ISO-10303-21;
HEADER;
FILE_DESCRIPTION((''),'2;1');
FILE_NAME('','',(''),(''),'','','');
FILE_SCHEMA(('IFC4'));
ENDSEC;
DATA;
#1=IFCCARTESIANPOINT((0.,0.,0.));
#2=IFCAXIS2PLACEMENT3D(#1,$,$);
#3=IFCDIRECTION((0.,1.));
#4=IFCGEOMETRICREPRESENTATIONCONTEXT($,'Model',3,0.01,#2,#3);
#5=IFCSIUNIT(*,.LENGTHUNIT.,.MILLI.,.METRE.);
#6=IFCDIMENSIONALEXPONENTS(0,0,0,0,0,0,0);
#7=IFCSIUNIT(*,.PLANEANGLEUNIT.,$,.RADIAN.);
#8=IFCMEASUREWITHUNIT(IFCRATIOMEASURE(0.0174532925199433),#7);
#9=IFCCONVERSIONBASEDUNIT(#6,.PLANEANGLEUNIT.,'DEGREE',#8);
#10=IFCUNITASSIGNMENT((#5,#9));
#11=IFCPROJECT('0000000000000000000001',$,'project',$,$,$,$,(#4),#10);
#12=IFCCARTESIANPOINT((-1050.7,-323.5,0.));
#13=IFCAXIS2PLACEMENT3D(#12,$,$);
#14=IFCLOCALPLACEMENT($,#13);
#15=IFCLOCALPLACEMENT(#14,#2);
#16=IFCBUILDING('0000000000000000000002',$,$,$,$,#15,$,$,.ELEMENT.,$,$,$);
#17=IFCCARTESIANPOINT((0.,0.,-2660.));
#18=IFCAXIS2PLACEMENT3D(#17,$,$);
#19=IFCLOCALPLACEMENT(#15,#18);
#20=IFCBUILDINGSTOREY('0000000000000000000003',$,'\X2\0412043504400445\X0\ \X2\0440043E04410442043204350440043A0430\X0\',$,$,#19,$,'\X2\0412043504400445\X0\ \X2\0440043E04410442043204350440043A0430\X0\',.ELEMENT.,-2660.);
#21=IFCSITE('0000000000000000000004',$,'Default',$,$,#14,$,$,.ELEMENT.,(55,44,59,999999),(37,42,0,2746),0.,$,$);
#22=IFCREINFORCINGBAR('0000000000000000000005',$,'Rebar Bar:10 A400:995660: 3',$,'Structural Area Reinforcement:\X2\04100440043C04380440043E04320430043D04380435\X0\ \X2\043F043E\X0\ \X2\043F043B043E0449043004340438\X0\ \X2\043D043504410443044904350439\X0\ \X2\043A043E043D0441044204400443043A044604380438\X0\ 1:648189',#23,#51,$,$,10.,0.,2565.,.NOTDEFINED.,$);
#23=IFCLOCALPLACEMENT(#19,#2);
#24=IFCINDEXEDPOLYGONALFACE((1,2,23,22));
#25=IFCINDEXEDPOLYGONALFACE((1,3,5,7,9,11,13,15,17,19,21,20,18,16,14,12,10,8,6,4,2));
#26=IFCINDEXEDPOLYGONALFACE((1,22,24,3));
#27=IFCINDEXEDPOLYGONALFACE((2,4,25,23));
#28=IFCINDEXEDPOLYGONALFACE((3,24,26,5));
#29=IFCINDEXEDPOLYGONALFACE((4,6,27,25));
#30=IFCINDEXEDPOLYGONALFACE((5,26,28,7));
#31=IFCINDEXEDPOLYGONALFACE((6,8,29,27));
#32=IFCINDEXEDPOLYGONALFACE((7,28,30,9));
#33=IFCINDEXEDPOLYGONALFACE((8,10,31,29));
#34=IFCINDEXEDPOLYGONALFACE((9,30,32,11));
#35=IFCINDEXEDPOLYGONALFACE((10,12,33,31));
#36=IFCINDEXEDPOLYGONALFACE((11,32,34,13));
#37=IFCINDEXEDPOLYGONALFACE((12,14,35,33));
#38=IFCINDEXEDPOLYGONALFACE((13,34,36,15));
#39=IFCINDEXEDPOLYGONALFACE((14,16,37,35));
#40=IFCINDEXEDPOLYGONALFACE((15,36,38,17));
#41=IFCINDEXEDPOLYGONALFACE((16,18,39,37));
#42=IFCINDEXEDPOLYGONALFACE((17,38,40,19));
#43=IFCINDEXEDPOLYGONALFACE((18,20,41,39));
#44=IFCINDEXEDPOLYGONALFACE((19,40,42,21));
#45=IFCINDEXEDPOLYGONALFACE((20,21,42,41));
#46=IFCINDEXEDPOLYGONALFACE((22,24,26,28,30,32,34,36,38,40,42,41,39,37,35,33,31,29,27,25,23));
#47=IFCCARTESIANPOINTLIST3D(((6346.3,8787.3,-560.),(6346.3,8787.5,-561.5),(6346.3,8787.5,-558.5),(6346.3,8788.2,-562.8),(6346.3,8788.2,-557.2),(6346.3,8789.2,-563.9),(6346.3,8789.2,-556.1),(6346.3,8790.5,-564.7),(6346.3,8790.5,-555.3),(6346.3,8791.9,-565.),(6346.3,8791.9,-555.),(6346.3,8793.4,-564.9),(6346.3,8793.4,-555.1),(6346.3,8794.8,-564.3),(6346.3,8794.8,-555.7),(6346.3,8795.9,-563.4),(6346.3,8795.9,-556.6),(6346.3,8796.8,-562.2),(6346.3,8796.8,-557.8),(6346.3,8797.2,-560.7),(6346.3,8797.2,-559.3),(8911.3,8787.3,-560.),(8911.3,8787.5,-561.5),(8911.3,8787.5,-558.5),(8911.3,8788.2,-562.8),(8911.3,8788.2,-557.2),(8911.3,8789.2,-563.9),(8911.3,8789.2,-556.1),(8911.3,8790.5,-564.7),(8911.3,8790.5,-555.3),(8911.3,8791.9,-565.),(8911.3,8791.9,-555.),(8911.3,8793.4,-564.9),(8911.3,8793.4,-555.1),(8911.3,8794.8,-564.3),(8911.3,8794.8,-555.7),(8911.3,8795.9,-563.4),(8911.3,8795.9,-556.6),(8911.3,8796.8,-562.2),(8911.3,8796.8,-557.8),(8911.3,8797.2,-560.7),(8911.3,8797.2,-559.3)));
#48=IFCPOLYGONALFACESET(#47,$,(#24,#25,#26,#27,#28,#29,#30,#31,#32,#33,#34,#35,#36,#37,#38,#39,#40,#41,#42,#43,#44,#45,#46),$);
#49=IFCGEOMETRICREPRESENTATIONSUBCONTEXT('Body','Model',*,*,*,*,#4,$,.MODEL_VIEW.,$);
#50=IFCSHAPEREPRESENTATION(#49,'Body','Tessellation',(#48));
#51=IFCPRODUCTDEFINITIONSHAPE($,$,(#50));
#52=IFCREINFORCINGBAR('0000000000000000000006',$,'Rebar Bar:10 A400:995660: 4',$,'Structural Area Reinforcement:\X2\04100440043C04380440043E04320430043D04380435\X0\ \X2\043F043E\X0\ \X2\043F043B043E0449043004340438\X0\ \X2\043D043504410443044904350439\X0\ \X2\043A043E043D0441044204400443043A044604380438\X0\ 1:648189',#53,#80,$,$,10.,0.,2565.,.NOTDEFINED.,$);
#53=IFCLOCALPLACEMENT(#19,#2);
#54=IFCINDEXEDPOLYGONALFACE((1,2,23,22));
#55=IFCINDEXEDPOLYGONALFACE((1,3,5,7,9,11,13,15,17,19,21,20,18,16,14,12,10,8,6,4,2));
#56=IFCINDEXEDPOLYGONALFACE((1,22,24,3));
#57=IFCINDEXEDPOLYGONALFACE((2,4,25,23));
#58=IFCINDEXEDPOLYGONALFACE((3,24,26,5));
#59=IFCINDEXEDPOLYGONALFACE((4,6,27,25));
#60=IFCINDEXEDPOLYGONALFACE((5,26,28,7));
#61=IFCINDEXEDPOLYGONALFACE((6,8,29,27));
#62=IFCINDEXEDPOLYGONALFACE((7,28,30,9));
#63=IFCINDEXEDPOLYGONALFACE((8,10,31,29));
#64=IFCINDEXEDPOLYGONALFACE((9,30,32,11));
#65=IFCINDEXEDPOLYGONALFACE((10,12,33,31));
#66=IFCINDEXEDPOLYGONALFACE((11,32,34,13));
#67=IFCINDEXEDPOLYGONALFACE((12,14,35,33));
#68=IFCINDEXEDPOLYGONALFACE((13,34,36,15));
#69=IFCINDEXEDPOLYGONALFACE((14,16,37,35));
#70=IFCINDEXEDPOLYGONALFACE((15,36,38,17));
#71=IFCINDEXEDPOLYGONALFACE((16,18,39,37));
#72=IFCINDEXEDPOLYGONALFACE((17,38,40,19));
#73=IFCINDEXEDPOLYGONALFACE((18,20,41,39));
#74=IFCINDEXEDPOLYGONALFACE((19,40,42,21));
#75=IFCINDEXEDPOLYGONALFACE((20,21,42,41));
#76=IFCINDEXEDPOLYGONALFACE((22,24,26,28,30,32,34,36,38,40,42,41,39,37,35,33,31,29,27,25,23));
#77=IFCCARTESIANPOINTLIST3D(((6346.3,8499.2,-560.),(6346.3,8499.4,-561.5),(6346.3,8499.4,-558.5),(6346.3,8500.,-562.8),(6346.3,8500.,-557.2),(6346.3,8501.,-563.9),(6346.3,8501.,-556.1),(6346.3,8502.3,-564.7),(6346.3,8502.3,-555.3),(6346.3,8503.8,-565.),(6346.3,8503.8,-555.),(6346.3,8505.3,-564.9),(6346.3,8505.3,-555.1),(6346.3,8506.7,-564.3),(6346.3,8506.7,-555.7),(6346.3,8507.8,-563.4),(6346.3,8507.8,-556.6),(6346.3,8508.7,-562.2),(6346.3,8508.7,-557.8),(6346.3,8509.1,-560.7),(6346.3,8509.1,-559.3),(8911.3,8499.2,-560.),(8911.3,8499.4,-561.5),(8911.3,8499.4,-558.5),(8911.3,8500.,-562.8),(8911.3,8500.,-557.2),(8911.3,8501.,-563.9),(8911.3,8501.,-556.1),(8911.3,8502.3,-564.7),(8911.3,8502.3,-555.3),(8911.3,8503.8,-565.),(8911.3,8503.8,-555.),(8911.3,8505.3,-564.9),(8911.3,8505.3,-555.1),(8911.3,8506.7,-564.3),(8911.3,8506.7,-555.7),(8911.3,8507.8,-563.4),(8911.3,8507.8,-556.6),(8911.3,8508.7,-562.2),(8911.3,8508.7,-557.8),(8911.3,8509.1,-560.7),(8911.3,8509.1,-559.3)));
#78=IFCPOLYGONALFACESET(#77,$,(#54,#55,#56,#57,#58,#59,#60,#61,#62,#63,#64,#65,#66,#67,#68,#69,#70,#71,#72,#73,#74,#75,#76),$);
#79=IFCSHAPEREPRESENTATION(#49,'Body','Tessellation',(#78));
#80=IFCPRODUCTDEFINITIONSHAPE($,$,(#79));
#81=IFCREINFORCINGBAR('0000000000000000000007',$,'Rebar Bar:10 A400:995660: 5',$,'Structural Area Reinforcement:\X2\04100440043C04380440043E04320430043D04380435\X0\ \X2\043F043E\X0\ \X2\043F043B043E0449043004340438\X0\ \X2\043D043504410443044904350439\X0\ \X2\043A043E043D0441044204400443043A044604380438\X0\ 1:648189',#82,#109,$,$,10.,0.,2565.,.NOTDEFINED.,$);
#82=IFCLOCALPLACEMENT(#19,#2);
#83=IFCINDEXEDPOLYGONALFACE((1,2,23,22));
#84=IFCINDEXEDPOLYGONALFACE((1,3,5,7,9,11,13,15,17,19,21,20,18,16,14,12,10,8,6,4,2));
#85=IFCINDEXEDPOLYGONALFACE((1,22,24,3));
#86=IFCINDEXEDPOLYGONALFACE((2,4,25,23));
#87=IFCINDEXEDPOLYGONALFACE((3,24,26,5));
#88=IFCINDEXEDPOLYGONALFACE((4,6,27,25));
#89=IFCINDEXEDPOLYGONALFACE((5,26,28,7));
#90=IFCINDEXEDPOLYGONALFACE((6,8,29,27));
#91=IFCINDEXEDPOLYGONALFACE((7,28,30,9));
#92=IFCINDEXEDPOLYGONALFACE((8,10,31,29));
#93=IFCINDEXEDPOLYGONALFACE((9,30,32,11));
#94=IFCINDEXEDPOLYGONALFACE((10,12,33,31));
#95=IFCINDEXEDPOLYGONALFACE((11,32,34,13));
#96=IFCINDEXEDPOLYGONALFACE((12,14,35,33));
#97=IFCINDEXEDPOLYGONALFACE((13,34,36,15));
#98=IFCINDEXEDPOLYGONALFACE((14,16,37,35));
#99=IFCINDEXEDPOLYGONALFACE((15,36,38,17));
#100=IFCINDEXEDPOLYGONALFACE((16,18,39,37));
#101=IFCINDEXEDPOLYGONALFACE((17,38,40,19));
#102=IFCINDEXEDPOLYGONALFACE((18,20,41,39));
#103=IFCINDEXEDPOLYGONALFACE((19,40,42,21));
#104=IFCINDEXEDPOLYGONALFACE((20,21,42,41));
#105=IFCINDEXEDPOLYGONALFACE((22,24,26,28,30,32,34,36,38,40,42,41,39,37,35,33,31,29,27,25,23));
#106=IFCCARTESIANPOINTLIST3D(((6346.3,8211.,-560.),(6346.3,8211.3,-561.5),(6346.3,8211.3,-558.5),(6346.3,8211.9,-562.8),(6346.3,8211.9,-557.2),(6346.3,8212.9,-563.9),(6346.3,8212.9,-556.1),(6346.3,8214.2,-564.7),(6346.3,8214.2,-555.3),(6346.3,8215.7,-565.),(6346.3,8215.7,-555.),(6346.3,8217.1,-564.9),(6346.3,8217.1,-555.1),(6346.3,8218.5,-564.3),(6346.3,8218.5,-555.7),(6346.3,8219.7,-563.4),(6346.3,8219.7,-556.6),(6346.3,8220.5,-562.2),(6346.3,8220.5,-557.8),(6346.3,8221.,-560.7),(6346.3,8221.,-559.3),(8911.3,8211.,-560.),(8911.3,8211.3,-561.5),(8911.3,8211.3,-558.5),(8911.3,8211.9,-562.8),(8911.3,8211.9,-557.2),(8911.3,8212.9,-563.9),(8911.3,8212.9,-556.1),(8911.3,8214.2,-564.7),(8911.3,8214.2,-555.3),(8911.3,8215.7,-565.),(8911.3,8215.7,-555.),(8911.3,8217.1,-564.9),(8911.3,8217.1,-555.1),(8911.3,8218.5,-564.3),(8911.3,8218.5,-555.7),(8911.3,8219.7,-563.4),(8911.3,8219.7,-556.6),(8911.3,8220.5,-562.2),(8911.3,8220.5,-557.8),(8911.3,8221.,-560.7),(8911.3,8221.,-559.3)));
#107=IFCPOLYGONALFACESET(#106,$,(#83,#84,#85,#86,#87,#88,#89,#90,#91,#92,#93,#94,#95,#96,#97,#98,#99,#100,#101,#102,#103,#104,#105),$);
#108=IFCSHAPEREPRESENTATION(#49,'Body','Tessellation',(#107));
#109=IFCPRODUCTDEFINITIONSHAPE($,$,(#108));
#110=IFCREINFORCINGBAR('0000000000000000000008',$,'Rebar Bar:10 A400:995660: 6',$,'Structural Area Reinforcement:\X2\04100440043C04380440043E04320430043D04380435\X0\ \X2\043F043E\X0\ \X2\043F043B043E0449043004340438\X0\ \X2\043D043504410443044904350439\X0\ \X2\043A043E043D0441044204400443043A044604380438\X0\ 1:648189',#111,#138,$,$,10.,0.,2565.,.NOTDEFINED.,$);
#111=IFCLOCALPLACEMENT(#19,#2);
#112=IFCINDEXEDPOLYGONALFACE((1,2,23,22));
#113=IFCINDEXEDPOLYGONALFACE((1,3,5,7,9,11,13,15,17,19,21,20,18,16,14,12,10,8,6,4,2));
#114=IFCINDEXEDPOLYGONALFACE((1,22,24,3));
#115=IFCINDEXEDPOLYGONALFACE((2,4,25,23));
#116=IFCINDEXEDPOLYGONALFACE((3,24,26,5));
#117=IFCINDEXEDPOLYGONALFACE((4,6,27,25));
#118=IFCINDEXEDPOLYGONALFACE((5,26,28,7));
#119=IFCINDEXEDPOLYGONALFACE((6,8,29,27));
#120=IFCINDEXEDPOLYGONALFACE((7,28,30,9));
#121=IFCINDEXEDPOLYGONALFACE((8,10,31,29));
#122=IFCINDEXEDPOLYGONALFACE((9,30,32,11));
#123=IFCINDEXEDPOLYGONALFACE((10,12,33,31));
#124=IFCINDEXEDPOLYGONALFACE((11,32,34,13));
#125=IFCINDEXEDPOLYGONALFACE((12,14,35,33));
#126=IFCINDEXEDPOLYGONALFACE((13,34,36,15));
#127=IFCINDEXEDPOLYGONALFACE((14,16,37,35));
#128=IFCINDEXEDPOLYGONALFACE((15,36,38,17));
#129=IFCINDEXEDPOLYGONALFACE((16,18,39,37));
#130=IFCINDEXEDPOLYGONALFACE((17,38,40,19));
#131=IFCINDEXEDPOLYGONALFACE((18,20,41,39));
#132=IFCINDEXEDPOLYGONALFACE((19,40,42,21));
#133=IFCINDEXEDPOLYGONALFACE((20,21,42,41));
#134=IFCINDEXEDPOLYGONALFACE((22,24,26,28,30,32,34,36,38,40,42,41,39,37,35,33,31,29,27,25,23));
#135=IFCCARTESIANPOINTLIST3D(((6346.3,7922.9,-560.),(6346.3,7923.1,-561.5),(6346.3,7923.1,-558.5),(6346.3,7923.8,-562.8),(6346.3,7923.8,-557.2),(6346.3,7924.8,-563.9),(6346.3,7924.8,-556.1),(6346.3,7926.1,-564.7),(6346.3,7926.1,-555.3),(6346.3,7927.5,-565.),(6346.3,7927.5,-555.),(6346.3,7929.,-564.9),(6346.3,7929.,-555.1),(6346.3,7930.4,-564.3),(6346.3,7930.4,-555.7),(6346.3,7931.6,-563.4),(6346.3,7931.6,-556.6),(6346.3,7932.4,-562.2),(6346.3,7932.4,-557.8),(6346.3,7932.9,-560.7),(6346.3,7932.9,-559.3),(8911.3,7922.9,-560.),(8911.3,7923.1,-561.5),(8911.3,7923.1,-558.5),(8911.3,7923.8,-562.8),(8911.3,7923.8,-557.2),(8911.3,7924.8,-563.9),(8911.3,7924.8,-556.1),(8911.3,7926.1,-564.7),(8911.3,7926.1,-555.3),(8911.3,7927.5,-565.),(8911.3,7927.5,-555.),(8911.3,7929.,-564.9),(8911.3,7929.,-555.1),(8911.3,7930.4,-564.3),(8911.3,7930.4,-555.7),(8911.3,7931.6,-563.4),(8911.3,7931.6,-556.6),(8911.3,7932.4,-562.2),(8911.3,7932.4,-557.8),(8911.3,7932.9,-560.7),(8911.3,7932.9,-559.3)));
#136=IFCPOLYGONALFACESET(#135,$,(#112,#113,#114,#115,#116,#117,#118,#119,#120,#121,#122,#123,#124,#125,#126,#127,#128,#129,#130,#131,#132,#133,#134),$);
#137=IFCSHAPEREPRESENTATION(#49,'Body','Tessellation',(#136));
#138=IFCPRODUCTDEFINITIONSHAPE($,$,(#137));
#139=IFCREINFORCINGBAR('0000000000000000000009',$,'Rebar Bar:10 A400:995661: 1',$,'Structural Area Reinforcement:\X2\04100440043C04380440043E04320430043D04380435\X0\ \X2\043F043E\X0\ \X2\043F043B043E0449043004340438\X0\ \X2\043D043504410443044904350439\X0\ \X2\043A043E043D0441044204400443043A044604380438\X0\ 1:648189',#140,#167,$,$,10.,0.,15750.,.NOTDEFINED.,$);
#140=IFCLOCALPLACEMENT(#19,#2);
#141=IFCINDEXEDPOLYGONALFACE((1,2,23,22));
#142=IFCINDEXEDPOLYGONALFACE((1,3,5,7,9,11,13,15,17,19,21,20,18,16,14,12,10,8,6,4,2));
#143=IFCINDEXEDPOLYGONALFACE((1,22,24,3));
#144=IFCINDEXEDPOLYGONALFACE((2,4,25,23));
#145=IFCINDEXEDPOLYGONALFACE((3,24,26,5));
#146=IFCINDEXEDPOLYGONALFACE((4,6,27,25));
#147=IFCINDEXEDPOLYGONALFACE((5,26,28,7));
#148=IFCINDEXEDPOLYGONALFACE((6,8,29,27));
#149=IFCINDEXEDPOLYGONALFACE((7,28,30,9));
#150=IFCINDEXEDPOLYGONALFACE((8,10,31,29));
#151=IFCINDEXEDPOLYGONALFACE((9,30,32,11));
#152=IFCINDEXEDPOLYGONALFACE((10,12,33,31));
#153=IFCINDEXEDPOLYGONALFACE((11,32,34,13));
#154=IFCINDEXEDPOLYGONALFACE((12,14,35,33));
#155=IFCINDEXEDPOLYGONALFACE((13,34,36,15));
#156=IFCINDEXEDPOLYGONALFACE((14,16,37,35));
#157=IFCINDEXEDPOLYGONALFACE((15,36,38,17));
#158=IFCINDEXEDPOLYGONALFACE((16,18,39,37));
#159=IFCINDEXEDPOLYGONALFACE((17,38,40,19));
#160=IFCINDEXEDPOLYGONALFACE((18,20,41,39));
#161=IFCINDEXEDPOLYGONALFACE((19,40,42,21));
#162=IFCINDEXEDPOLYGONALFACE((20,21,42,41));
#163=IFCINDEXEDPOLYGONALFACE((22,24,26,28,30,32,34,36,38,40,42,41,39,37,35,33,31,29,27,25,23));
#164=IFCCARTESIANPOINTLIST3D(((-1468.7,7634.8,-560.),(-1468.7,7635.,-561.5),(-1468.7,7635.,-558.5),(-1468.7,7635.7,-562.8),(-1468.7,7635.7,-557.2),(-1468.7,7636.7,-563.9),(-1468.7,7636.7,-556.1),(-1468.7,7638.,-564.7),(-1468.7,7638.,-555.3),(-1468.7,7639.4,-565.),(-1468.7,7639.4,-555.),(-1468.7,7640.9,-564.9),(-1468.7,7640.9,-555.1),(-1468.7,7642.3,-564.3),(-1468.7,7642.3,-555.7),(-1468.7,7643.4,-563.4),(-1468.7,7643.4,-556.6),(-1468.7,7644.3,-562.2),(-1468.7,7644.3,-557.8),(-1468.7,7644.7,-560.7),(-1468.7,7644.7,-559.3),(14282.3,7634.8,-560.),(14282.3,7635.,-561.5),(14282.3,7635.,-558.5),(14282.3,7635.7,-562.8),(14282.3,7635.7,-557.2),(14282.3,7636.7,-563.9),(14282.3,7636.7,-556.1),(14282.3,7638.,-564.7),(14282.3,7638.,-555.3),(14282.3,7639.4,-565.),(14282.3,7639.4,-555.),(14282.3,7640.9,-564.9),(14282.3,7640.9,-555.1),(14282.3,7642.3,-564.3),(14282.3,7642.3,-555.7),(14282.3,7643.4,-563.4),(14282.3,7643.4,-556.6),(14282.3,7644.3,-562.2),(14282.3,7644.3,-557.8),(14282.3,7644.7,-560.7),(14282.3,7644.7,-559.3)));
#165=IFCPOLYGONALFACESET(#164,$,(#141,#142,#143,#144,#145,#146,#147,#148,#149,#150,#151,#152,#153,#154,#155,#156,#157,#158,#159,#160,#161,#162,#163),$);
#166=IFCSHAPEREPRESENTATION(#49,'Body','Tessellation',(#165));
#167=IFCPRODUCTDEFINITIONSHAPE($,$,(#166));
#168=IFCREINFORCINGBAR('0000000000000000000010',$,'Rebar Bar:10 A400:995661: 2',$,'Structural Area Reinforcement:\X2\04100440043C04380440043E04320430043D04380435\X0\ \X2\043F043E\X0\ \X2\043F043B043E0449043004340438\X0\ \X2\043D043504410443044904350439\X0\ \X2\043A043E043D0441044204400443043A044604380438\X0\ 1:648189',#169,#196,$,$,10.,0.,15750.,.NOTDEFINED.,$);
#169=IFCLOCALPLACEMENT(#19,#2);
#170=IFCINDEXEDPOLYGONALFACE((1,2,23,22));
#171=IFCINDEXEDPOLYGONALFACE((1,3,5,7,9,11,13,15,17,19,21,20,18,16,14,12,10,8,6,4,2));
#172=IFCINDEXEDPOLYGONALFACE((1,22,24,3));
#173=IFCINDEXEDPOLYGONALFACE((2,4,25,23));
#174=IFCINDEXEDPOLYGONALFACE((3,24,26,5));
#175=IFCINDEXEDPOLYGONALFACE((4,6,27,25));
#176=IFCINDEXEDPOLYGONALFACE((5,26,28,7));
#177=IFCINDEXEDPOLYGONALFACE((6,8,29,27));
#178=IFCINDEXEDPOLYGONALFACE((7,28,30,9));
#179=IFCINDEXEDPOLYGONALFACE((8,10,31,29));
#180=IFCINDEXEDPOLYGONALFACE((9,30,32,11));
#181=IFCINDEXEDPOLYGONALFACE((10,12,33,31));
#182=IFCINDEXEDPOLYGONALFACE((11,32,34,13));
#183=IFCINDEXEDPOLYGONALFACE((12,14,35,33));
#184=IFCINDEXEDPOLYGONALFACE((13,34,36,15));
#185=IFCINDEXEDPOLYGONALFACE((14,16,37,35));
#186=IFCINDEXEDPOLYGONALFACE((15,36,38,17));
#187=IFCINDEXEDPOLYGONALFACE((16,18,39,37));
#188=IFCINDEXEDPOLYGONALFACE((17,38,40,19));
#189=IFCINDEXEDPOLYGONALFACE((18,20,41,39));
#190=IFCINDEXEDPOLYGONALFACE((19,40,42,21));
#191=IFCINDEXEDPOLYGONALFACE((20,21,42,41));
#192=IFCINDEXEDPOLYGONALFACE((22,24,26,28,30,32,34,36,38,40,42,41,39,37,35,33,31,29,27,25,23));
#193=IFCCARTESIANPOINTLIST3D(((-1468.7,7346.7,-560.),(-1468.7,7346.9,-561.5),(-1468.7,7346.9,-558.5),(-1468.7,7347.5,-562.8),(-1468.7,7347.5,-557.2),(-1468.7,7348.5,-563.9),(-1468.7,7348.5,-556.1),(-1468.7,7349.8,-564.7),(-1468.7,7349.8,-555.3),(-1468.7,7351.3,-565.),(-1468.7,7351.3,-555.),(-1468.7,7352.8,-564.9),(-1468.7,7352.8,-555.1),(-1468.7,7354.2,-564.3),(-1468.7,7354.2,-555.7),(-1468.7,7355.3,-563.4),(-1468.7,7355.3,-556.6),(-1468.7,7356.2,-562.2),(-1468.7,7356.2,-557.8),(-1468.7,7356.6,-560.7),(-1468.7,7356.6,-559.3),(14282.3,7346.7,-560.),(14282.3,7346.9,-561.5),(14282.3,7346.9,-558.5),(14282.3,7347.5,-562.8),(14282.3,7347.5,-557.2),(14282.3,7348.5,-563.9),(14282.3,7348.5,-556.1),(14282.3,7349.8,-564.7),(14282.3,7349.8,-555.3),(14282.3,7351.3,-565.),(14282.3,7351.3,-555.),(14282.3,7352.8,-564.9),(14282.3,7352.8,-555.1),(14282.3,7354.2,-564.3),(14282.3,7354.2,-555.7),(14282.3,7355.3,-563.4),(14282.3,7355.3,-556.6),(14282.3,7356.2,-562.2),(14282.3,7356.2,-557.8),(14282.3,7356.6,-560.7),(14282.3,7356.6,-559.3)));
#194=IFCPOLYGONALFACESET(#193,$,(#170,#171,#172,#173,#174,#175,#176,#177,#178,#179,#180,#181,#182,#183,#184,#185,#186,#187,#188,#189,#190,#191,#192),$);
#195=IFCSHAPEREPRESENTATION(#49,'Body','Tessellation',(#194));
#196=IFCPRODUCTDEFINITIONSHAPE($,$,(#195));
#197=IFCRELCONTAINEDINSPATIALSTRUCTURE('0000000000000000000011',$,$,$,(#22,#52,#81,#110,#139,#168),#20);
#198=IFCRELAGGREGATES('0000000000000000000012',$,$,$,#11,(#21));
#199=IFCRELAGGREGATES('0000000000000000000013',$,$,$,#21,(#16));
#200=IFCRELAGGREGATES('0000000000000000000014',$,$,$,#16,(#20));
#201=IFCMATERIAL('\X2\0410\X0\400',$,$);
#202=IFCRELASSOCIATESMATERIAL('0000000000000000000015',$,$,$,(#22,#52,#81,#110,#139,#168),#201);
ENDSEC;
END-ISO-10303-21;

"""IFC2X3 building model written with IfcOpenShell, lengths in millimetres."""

from ifc_helpers import new_model, entity, si_unit, converted_unit, direction, frame, origin, place, context, subcontext, project, spatial, material, element, save


model = new_model("IFC2X3")

# Units and contexts
model_context = context("Model", 3, precision=0.01, world=origin(), true_north=direction((0.0, 1.0)))
body_context = subcontext(model_context, "Body", "Model", "MODEL_VIEW")
ifc_project = project(units=[si_unit("LENGTHUNIT", "METRE", prefix="MILLI"), converted_unit("PLANEANGLEUNIT", "DEGREE", entity("IfcRatioMeasure", 0.0174532925199433), si_unit("PLANEANGLEUNIT", "RADIAN"), dimensions=[0, 0, 0, 0, 0, 0, 0])], contexts=[model_context])

# Site, building, storey
site_placement = place(None, frame((-1050.7, -323.5, 0.0)))
site = spatial("IfcSite", under=ifc_project, at=site_placement, Name="Default", CompositionType="ELEMENT", RefLatitude=(55, 44, 59, 999999), RefLongitude=(37, 42, 0, 2746), RefElevation=0.0)
building_placement = place(site_placement, origin())
building = spatial("IfcBuilding", under=site, at=building_placement, CompositionType="ELEMENT")
storey_placement = place(building_placement, frame((0.0, 0.0, -2660.0)))
storey = spatial("IfcBuildingStorey", under=building, at=storey_placement, Name="Верх ростверка", LongName="Верх ростверка", CompositionType="ELEMENT", Elevation=-2660.0)

# Reinforcing bars
ifc_material = material(Name="А400")
reinforcing_bar_1_placement = place(storey_placement, origin())
element("IfcReinforcingBar", 1, at=reinforcing_bar_1_placement, inside=storey, material=ifc_material, Name="Rebar Bar:10 A400:995660: 3", ObjectType="Structural Area Reinforcement:Армирование по площади несущей конструкции 1:648189", BarLength=2565.0, BarRole="NOTDEFINED", CrossSectionArea=0.0, NominalDiameter=10.0, context=body_context, shape_type="AdvancedSweptSolid", body=[
    entity("IfcSweptDiskSolid", entity("IfcCompositeCurve", [entity("IfcCompositeCurveSegment", "CONTINUOUS", True, entity("IfcPolyline", [entity("IfcCartesianPoint", [8911.3, 8792.3, -560.0]), entity("IfcCartesianPoint", [6346.3, 8792.3, -560.0])]))], False), 5.0, None, 0.0, 1.0),
])
reinforcing_bar_2_placement = place(storey_placement, origin())
element("IfcReinforcingBar", 2, at=reinforcing_bar_2_placement, inside=storey, material=ifc_material, Name="Rebar Bar:10 A400:995660: 4", ObjectType="Structural Area Reinforcement:Армирование по площади несущей конструкции 1:648189", BarLength=2565.0, BarRole="NOTDEFINED", CrossSectionArea=0.0, NominalDiameter=10.0, context=body_context, shape_type="AdvancedSweptSolid", body=[
    entity("IfcSweptDiskSolid", entity("IfcCompositeCurve", [entity("IfcCompositeCurveSegment", "CONTINUOUS", True, entity("IfcPolyline", [entity("IfcCartesianPoint", [8911.3, 8504.2, -560.0]), entity("IfcCartesianPoint", [6346.3, 8504.2, -560.0])]))], False), 5.0, None, 0.0, 1.0),
])
reinforcing_bar_3_placement = place(storey_placement, origin())
element("IfcReinforcingBar", 3, at=reinforcing_bar_3_placement, inside=storey, material=ifc_material, Name="Rebar Bar:10 A400:995660: 5", ObjectType="Structural Area Reinforcement:Армирование по площади несущей конструкции 1:648189", BarLength=2565.0, BarRole="NOTDEFINED", CrossSectionArea=0.0, NominalDiameter=10.0, context=body_context, shape_type="AdvancedSweptSolid", body=[
    entity("IfcSweptDiskSolid", entity("IfcCompositeCurve", [entity("IfcCompositeCurveSegment", "CONTINUOUS", True, entity("IfcPolyline", [entity("IfcCartesianPoint", [8911.3, 8216.0, -560.0]), entity("IfcCartesianPoint", [6346.3, 8216.0, -560.0])]))], False), 5.0, None, 0.0, 1.0),
])
reinforcing_bar_4_placement = place(storey_placement, origin())
element("IfcReinforcingBar", 4, at=reinforcing_bar_4_placement, inside=storey, material=ifc_material, Name="Rebar Bar:10 A400:995660: 6", ObjectType="Structural Area Reinforcement:Армирование по площади несущей конструкции 1:648189", BarLength=2565.0, BarRole="NOTDEFINED", CrossSectionArea=0.0, NominalDiameter=10.0, context=body_context, shape_type="AdvancedSweptSolid", body=[
    entity("IfcSweptDiskSolid", entity("IfcCompositeCurve", [entity("IfcCompositeCurveSegment", "CONTINUOUS", True, entity("IfcPolyline", [entity("IfcCartesianPoint", [8911.3, 7927.9, -560.0]), entity("IfcCartesianPoint", [6346.3, 7927.9, -560.0])]))], False), 5.0, None, 0.0, 1.0),
])
reinforcing_bar_5_placement = place(storey_placement, origin())
element("IfcReinforcingBar", 5, at=reinforcing_bar_5_placement, inside=storey, material=ifc_material, Name="Rebar Bar:10 A400:995661: 1", ObjectType="Structural Area Reinforcement:Армирование по площади несущей конструкции 1:648189", BarLength=15750.0, BarRole="NOTDEFINED", CrossSectionArea=0.0, NominalDiameter=10.0, context=body_context, shape_type="AdvancedSweptSolid", body=[
    entity("IfcSweptDiskSolid", entity("IfcCompositeCurve", [entity("IfcCompositeCurveSegment", "CONTINUOUS", True, entity("IfcPolyline", [entity("IfcCartesianPoint", [14282.3, 7639.8, -560.0]), entity("IfcCartesianPoint", [-1468.7, 7639.8, -560.0])]))], False), 5.0, None, 0.0, 1.0),
])
reinforcing_bar_6_placement = place(storey_placement, origin())
element("IfcReinforcingBar", 6, at=reinforcing_bar_6_placement, inside=storey, material=ifc_material, Name="Rebar Bar:10 A400:995661: 2", ObjectType="Structural Area Reinforcement:Армирование по площади несущей конструкции 1:648189", BarLength=15750.0, BarRole="NOTDEFINED", CrossSectionArea=0.0, NominalDiameter=10.0, context=body_context, shape_type="AdvancedSweptSolid", body=[
    entity("IfcSweptDiskSolid", entity("IfcCompositeCurve", [entity("IfcCompositeCurveSegment", "CONTINUOUS", True, entity("IfcPolyline", [entity("IfcCartesianPoint", [14282.3, 7351.7, -560.0]), entity("IfcCartesianPoint", [-1468.7, 7351.7, -560.0])]))], False), 5.0, None, 0.0, 1.0),
])

save(model, "model.ifc")
